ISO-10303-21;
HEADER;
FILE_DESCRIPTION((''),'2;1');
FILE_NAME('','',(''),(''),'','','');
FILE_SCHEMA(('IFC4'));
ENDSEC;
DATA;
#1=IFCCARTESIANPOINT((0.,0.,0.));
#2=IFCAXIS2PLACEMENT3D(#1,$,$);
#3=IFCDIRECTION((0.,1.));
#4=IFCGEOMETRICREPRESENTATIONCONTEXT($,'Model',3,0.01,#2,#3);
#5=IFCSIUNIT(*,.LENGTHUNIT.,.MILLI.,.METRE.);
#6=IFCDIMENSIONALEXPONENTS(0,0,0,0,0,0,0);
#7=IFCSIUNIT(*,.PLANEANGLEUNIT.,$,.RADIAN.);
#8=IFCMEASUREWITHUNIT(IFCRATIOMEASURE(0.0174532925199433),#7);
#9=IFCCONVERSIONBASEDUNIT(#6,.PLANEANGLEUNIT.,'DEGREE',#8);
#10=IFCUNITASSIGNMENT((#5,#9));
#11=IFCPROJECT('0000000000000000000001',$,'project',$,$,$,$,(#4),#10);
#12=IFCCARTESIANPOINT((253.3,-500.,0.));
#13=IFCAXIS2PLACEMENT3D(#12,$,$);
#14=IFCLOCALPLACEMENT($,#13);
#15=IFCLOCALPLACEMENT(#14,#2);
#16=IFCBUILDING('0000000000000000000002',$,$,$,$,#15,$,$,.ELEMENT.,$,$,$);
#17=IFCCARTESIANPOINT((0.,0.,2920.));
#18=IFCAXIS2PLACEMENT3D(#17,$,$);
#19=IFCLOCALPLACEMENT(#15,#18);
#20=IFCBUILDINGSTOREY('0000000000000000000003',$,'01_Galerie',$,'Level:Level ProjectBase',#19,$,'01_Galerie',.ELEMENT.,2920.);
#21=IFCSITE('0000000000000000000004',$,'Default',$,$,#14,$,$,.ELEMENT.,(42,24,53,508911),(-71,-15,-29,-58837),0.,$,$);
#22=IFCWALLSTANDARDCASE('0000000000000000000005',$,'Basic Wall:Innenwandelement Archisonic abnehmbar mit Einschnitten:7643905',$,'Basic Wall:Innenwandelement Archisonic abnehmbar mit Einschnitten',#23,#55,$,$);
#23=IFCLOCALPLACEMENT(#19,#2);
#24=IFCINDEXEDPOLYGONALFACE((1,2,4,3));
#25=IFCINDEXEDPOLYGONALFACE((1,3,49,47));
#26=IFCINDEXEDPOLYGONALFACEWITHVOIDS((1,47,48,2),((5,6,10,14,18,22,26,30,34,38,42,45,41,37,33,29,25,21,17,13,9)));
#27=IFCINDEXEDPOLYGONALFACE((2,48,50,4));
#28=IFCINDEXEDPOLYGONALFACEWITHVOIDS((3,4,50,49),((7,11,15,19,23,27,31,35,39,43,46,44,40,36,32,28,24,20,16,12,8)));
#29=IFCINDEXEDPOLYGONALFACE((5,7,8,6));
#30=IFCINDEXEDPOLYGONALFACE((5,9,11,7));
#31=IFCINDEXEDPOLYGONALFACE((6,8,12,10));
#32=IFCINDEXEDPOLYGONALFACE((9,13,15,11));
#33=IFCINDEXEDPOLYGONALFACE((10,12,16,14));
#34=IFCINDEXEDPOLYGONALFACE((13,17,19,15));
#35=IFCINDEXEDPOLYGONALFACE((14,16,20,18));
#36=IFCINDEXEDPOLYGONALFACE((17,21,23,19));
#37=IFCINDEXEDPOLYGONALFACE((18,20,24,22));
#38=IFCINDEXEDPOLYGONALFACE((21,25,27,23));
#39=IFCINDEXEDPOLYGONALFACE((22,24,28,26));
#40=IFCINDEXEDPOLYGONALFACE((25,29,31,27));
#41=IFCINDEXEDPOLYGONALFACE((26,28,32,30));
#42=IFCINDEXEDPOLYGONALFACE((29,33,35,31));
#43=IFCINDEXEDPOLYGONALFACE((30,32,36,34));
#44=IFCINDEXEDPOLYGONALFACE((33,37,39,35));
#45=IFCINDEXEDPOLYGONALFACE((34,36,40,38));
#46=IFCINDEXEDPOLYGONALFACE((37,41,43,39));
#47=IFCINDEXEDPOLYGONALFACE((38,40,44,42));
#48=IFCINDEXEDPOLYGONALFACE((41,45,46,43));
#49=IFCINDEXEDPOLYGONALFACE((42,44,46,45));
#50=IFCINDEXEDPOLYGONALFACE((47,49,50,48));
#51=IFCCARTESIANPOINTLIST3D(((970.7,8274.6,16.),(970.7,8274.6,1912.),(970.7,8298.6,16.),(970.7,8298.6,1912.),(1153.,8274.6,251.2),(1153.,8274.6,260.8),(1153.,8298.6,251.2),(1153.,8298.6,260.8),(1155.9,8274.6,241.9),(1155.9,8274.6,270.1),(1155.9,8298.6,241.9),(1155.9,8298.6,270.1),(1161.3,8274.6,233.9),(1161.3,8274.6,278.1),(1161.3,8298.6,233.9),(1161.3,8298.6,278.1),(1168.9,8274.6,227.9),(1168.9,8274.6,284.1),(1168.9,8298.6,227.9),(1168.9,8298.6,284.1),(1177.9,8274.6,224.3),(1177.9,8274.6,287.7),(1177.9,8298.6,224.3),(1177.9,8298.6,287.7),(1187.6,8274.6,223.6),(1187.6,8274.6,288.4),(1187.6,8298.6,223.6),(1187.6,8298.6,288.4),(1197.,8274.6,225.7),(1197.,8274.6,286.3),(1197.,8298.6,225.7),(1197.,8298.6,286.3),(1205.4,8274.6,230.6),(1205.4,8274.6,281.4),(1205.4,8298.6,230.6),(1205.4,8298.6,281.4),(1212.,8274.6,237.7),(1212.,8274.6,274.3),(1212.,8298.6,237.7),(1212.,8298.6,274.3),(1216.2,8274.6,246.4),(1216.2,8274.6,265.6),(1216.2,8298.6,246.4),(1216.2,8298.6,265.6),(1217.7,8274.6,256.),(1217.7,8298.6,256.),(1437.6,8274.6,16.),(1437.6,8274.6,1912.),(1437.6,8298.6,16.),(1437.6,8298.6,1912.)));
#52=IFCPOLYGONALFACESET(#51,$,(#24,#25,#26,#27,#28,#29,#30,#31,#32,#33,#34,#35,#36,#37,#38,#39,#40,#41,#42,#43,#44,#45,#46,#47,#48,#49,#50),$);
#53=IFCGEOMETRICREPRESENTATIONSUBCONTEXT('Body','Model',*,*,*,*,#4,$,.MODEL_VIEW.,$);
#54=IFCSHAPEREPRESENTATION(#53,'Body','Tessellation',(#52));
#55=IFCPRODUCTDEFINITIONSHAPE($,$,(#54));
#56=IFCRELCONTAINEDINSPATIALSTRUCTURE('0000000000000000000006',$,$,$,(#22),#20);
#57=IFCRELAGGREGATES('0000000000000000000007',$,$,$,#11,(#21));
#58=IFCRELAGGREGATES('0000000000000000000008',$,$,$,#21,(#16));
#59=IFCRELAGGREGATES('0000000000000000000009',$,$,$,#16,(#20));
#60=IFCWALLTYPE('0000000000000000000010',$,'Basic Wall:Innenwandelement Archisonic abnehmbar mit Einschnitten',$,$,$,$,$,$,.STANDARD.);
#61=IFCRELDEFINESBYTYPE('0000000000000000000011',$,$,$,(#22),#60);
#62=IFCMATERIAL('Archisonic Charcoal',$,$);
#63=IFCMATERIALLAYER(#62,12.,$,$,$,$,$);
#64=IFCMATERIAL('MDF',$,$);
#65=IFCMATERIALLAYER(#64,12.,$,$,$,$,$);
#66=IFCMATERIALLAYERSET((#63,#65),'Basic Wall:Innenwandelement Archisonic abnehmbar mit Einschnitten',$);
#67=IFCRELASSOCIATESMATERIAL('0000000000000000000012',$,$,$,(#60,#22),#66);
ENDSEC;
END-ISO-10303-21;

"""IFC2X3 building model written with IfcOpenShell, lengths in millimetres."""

from ifc_helpers import new_model, entity, si_unit, converted_unit, direction, frame, frame_2d, origin, origin_2d_with_axis, place, context, subcontext, project, spatial, rectangle, circle, extrude, material, layer, layer_set, layer_usage, type_object, element, save


model = new_model("IFC2X3")

# Units and contexts
model_context = context("Model", 3, precision=0.01, world=origin(), true_north=direction((0.0, 1.0)))
body_context = subcontext(model_context, "Body", "Model", "MODEL_VIEW")
ifc_project = project(units=[si_unit("LENGTHUNIT", "METRE", prefix="MILLI"), converted_unit("PLANEANGLEUNIT", "DEGREE", entity("IfcRatioMeasure", 0.0174532925199433), si_unit("PLANEANGLEUNIT", "RADIAN"), dimensions=[0, 0, 0, 0, 0, 0, 0])], contexts=[model_context])

# Site, building, storey
site_placement = place(None, frame((253.3, -500.0, 0.0)))
site = spatial("IfcSite", under=ifc_project, at=site_placement, Name="Default", CompositionType="ELEMENT", RefLatitude=(42, 24, 53, 508911), RefLongitude=(-71, -15, -29, -58837), RefElevation=0.0)
building_placement = place(site_placement, origin())
building = spatial("IfcBuilding", under=site, at=building_placement, CompositionType="ELEMENT")
storey_placement = place(building_placement, frame((0.0, 0.0, 2920.0)))
storey = spatial("IfcBuildingStorey", under=building, at=storey_placement, Name="01_Galerie", ObjectType="Level:Level ProjectBase", LongName="01_Galerie", CompositionType="ELEMENT", Elevation=2920.0)

# Shared definitions
ifc_material_1 = material(Name="Archisonic Charcoal")
ifc_material_2 = material(Name="MDF")

# Shared definitions
ifc_layer_1 = layer(ifc_material_1, 12.0)
ifc_layer_2 = layer(ifc_material_2, 12.0)
ifc_layer_set_1 = layer_set([ifc_layer_1, ifc_layer_2], Name="Basic Wall:Innenwandelement Archisonic abnehmbar mit Einschnitten")
wall_type_1 = type_object("IfcWallType", Name="Basic Wall:Innenwandelement Archisonic abnehmbar mit Einschnitten", PredefinedType="STANDARD", material=ifc_layer_set_1)

# Wall, opening
ifc_layer_usage_1 = layer_usage(ifc_layer_set_1, "AXIS2", "NEGATIVE", 12.0)
wall_1_placement = place(storey_placement, frame((1437.6, 8286.6, 16.0), z_axis=(0.0, 0.0, 1.0), x_axis=(-1.0, 0.0, 0.0)))
wall_1 = element("IfcWallStandardCase", 1, at=wall_1_placement, inside=storey, type_object=wall_type_1, material=ifc_layer_usage_1, Name="Basic Wall:Innenwandelement Archisonic abnehmbar mit Einschnitten:7643905", ObjectType="Basic Wall:Innenwandelement Archisonic abnehmbar mit Einschnitten", context=body_context, shape_type="SweptSolid", body=[
    extrude(rectangle(XDim=466.9, YDim=24.0, at=frame_2d((233.5, 0.0), x_axis=(-1.0, 0.0))), origin(), (0.0, 0.0, 1.0), 1896.0),
])
opening_1_placement = place(wall_1_placement, frame((286.5, 12.0, 205.9)))
element("IfcOpeningElement", 2, at=opening_1_placement, cuts=wall_1, ObjectType="Opening", context=body_context, shape_type="SweptSolid", body=[
    extrude(circle(Radius=32.5, at=origin_2d_with_axis()), frame((-34.1, -59.0, 34.1), z_axis=(0.0, 1.0, 0.0), x_axis=(-1.0, 0.0, 0.0)), (0.0, 0.0, 1.0), 59.0),
])

save(model, "model.ifc")
